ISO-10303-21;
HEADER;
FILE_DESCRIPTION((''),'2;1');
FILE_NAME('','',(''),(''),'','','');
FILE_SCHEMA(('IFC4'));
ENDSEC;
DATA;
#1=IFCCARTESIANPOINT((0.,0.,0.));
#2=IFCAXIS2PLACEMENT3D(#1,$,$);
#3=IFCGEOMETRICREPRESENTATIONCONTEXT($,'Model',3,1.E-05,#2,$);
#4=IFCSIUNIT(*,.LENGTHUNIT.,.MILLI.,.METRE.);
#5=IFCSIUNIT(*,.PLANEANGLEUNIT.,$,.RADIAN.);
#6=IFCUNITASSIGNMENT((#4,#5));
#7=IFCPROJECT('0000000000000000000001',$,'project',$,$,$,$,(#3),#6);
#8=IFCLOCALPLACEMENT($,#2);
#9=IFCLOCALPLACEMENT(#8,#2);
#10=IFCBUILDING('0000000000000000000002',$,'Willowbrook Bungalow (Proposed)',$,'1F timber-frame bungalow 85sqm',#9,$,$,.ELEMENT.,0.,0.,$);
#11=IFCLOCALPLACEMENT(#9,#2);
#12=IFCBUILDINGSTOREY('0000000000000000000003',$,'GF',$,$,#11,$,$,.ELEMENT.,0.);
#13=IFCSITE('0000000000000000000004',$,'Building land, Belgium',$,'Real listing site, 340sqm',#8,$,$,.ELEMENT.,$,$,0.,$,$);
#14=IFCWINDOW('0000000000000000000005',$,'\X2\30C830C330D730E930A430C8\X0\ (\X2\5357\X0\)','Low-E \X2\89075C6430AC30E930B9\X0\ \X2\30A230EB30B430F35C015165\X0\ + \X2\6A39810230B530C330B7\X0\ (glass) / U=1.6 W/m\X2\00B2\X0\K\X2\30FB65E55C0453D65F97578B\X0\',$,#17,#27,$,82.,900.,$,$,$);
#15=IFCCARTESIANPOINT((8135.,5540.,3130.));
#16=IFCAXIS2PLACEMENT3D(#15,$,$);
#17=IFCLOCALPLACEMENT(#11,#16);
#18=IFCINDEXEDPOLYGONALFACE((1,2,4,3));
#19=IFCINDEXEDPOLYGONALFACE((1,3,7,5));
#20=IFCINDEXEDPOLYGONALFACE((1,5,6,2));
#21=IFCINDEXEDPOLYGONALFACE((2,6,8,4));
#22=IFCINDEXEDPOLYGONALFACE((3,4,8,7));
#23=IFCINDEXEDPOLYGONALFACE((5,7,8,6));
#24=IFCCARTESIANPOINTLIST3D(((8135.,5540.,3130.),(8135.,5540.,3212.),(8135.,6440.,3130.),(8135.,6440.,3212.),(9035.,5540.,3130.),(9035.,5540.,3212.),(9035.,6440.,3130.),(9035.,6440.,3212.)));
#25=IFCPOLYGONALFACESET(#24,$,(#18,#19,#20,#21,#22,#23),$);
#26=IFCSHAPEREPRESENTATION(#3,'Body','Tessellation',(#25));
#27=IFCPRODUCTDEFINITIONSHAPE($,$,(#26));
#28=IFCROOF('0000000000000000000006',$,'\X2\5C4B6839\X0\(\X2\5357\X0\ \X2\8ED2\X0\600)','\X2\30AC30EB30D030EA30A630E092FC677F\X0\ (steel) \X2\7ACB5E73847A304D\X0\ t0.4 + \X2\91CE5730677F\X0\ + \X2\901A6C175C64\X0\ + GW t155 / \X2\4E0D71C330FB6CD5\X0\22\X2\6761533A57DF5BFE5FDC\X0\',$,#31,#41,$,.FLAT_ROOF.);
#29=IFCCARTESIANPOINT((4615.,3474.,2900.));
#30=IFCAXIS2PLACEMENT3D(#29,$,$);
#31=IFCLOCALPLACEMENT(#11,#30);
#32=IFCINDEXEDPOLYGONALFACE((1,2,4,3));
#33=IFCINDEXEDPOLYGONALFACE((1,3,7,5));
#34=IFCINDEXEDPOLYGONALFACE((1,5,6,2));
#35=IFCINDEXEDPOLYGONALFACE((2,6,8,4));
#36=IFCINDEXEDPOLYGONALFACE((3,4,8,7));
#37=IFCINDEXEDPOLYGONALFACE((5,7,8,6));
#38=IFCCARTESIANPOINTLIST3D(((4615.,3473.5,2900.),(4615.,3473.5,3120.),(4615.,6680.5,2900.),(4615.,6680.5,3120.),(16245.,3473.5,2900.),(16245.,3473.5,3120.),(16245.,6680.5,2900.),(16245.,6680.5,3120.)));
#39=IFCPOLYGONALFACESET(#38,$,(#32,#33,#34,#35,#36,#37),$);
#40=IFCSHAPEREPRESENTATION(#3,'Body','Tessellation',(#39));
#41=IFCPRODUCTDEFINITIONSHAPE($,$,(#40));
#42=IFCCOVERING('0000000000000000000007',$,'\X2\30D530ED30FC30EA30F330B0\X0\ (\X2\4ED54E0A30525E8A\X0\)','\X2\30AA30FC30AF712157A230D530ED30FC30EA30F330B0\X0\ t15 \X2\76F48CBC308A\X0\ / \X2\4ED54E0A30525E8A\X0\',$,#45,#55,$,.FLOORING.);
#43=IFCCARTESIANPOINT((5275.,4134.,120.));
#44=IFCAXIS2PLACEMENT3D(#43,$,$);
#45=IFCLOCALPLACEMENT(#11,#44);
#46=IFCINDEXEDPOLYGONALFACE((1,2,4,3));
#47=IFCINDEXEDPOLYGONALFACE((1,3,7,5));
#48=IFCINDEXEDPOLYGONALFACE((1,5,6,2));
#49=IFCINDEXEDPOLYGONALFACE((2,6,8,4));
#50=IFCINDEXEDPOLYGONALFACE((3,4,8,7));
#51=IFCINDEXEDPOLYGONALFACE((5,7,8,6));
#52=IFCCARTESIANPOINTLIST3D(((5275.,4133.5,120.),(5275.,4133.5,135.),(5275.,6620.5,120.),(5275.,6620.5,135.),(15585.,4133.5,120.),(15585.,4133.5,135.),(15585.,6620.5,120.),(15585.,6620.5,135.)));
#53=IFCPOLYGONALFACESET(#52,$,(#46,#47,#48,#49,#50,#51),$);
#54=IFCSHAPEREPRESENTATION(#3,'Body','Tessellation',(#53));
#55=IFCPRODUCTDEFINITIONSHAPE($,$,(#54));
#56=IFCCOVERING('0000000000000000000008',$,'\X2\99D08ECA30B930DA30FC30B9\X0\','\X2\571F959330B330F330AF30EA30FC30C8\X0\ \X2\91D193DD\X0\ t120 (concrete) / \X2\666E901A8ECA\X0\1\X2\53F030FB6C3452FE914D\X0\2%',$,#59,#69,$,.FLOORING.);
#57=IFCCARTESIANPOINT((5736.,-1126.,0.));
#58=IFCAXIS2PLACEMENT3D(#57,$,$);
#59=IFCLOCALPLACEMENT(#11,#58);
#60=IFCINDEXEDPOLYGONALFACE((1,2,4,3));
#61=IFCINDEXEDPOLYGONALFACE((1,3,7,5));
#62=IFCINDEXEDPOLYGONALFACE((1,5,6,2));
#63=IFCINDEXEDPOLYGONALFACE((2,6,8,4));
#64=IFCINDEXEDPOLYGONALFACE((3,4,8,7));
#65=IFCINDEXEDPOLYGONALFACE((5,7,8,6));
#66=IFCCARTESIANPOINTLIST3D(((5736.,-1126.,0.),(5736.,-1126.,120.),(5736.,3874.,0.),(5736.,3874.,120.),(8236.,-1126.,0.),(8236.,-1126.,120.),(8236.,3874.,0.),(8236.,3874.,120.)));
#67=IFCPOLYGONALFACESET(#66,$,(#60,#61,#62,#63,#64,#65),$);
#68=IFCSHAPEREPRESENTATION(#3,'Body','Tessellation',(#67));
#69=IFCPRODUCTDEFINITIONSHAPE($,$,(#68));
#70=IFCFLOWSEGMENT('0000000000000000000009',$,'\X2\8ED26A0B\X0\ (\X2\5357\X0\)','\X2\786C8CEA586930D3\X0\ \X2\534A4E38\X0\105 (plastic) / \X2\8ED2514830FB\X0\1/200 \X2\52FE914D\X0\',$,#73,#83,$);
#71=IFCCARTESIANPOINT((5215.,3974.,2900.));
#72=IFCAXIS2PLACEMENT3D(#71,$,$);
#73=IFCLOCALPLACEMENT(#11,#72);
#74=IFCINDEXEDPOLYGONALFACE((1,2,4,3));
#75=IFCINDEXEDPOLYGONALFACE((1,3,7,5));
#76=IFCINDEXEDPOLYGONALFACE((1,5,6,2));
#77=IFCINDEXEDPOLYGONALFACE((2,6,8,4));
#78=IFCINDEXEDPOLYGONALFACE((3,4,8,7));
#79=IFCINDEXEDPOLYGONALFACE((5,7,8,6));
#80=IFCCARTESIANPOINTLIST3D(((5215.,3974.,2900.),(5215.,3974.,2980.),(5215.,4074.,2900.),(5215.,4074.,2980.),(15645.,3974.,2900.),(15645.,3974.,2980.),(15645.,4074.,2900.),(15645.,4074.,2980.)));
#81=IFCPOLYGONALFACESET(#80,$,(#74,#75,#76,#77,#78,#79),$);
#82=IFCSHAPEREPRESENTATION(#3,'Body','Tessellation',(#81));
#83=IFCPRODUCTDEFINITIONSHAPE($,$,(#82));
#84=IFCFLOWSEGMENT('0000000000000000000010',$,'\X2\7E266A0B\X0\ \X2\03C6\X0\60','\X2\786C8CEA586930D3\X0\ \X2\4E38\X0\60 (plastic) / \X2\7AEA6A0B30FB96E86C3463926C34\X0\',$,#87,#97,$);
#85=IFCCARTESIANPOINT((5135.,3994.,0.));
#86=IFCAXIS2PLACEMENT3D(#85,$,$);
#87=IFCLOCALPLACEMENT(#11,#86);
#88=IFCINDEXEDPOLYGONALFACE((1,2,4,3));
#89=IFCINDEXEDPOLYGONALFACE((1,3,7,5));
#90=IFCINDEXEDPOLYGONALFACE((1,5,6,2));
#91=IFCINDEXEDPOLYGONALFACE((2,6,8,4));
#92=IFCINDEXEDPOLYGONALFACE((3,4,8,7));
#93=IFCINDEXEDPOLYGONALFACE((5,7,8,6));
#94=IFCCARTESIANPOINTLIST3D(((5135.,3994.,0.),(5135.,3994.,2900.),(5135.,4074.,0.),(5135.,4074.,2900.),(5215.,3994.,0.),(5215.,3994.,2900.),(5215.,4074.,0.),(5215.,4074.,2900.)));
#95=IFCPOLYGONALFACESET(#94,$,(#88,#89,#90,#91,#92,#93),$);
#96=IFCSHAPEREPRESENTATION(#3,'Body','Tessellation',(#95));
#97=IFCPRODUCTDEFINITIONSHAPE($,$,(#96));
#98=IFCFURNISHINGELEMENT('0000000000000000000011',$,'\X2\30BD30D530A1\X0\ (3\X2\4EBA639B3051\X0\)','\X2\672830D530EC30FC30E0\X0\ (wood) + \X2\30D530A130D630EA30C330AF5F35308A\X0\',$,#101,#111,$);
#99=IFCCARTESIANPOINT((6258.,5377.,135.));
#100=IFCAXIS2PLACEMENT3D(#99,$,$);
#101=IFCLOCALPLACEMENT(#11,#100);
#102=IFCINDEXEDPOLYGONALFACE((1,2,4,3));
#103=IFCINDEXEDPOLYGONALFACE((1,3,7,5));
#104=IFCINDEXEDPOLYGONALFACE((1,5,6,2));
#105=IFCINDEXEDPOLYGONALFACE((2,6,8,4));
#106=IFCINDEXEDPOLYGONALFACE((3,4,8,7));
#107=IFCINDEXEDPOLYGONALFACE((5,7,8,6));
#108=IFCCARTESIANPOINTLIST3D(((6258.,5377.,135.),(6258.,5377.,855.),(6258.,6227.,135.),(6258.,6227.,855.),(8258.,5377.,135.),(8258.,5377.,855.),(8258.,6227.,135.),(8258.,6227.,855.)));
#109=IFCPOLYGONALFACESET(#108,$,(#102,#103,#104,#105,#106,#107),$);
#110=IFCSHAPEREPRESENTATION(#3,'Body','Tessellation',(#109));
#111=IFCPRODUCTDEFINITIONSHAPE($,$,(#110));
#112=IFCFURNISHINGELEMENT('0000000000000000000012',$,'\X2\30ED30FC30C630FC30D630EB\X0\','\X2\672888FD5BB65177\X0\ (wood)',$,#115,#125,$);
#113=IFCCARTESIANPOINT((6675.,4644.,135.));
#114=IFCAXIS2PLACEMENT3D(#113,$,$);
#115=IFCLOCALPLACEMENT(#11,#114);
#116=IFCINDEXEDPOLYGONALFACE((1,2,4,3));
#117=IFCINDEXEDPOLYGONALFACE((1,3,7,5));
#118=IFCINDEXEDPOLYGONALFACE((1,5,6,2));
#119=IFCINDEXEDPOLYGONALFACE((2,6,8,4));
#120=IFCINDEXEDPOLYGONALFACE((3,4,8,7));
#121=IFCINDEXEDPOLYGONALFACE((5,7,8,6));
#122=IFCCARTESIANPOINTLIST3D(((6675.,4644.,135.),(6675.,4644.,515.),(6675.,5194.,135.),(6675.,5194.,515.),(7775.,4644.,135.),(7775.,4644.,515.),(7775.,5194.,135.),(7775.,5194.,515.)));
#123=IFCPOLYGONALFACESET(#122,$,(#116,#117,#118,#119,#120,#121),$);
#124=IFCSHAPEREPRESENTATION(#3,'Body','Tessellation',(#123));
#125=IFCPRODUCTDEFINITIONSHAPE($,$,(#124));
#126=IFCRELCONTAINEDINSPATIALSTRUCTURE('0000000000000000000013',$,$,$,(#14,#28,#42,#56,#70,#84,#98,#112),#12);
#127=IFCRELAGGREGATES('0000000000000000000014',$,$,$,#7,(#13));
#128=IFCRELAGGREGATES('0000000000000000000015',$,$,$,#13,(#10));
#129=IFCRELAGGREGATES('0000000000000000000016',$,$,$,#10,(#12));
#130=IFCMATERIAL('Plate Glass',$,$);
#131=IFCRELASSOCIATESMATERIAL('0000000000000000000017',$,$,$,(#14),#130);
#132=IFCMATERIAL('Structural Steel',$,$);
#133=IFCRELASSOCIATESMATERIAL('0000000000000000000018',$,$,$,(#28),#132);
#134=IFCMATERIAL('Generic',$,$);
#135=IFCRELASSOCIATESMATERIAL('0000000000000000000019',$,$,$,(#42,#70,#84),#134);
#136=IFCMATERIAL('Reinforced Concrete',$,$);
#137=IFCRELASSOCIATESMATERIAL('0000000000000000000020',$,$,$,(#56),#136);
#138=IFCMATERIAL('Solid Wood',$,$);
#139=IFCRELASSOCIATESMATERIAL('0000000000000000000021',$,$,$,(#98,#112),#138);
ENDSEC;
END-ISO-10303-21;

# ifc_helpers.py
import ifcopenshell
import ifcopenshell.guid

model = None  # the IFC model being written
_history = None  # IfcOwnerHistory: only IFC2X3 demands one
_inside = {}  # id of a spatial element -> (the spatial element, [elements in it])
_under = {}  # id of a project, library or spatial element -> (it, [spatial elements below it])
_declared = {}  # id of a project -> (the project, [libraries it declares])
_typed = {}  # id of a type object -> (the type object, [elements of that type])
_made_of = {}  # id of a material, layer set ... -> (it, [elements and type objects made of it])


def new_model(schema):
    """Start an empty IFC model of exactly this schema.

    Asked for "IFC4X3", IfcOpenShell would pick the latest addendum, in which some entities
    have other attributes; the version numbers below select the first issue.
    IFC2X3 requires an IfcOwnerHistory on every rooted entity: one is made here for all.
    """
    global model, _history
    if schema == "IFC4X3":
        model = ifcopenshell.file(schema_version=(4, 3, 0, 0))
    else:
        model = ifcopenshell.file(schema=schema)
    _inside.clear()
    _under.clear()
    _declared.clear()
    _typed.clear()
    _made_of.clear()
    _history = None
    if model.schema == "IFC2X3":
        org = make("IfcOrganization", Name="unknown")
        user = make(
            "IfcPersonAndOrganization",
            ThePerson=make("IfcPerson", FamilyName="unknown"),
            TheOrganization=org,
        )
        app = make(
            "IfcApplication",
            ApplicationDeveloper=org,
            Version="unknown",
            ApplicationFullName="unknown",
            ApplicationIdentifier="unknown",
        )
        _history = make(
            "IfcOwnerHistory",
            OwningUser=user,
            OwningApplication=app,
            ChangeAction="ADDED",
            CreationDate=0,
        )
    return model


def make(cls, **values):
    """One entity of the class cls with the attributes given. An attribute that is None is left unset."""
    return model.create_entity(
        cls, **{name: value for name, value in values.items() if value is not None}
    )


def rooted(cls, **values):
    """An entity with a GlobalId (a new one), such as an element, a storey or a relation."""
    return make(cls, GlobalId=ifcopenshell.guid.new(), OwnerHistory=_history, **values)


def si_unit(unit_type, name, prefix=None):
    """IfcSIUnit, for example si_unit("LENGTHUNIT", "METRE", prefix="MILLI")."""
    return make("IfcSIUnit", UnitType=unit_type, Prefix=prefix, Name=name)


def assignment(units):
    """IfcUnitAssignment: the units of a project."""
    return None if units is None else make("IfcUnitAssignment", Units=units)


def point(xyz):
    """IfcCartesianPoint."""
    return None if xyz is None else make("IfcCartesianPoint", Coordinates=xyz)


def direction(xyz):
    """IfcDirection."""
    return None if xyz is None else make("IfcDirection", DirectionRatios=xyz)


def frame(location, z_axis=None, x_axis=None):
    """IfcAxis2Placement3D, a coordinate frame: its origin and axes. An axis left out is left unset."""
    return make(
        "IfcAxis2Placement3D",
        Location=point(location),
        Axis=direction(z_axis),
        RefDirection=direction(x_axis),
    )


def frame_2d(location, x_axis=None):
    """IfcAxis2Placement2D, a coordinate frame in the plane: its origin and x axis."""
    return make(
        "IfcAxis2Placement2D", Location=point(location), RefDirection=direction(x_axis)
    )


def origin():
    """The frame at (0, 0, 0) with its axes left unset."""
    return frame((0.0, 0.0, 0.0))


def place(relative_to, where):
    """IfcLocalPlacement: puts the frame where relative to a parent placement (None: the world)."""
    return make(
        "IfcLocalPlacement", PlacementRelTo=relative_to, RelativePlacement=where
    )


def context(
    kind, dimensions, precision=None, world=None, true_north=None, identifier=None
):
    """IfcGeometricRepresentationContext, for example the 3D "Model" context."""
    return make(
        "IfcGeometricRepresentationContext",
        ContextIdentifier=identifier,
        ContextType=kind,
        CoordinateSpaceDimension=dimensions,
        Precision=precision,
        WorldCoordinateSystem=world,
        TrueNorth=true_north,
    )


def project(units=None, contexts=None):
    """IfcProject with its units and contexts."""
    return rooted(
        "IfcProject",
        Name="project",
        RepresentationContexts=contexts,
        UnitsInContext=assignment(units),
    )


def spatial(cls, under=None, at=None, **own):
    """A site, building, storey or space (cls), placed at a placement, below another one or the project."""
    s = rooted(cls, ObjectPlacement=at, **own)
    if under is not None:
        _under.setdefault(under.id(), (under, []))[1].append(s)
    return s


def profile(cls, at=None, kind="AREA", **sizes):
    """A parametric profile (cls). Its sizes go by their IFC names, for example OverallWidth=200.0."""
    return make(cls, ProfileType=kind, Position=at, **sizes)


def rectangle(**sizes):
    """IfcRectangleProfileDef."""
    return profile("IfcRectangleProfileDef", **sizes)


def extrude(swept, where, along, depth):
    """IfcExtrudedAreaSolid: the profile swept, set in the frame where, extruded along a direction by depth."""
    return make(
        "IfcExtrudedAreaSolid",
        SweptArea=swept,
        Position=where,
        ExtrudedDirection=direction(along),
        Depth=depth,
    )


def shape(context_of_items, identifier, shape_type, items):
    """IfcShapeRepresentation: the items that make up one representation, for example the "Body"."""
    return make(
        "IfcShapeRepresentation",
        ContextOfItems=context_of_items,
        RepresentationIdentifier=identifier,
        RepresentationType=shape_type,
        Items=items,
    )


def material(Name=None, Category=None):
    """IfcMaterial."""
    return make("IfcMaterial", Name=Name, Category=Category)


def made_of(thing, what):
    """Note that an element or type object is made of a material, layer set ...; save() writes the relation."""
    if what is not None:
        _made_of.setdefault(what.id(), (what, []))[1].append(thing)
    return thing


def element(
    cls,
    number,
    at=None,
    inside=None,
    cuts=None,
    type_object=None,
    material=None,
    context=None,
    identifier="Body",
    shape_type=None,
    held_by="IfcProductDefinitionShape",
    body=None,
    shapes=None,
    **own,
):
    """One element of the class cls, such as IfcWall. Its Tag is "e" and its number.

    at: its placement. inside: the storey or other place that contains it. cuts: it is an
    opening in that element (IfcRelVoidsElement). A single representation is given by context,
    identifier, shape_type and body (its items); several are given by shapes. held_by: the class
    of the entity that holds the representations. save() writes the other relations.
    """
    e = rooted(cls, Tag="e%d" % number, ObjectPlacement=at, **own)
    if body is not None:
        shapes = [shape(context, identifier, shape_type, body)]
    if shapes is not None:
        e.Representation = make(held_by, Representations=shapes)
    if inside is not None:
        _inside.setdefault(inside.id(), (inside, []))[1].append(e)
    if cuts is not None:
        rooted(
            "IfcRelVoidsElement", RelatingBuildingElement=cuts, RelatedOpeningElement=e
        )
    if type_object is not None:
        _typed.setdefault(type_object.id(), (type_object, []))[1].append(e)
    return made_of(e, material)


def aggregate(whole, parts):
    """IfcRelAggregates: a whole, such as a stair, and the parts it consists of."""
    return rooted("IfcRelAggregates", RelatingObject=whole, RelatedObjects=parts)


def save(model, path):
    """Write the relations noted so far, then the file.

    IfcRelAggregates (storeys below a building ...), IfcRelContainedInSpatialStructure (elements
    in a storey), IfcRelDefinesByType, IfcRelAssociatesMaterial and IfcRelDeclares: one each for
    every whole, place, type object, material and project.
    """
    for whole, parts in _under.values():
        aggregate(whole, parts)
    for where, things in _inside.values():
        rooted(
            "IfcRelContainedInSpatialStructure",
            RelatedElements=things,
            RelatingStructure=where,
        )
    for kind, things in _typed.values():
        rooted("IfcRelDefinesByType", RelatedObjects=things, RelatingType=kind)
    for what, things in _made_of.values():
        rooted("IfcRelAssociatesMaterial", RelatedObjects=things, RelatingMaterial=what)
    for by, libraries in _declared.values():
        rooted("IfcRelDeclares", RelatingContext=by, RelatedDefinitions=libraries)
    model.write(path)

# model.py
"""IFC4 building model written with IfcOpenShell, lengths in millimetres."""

from ifc_helpers import new_model, si_unit, frame, frame_2d, origin, place, context, project, spatial, rectangle, extrude, material, element, save


model = new_model("IFC4")

# Units and contexts
model_context = context("Model", 3, precision=1e-05, world=origin())
ifc_project = project(units=[si_unit("LENGTHUNIT", "METRE", prefix="MILLI"), si_unit("PLANEANGLEUNIT", "RADIAN")], contexts=[model_context])

# Site, building, storey
site_placement = place(None, origin())
site = spatial("IfcSite", under=ifc_project, at=site_placement, Name="Building land, Belgium", ObjectType="Real listing site, 340sqm", CompositionType="ELEMENT", RefElevation=0.0)
building_placement = place(site_placement, origin())
building = spatial("IfcBuilding", under=site, at=building_placement, Name="Willowbrook Bungalow (Proposed)", ObjectType="1F timber-frame bungalow 85sqm", CompositionType="ELEMENT", ElevationOfRefHeight=0.0, ElevationOfTerrain=0.0)
storey_placement = place(building_placement, origin())
storey = spatial("IfcBuildingStorey", under=building, at=storey_placement, Name="GF", CompositionType="ELEMENT", Elevation=0.0)

# Shared definitions
ifc_material_1 = material(Name="Solid Wood")

# Shared definitions
ifc_material_2 = material(Name="Reinforced Concrete")

# Shared definitions
ifc_material_3 = material(Name="Plate Glass")

# Window
window_1_placement = place(storey_placement, frame((8135.0, 5540.0, 3130.0)))
element("IfcWindow", 1, at=window_1_placement, inside=storey, material=ifc_material_3, Name="トップライト (南)", Description="Low-E 複層ガラス アルゴン封入 + 樹脂サッシ (glass) / U=1.6 W/m²K・日射取得型", OverallHeight=82.0, OverallWidth=900.0, context=model_context, shape_type="SweptSolid", body=[
    extrude(rectangle(XDim=900.0, YDim=900.0, at=frame_2d((450.0, 450.0))), frame((8135.0, 5540.0, 3130.0)), (0.0, 0.0, 1.0), 82.0),
])

# Roof
ifc_material_4 = material(Name="Structural Steel")
roof_1_placement = place(storey_placement, frame((4615.0, 3474.0, 2900.0)))
element("IfcRoof", 2, at=roof_1_placement, inside=storey, material=ifc_material_4, Name="屋根(南 軒600)", Description="ガルバリウム鋼板 (steel) 立平葺き t0.4 + 野地板 + 通気層 + GW t155 / 不燃・法22条区域対応", PredefinedType="FLAT_ROOF", context=model_context, shape_type="SweptSolid", body=[
    extrude(rectangle(XDim=11630.0, YDim=3207.0, at=frame_2d((5815.0, 1603.0))), frame((4615.0, 3474.0, 2900.0)), (0.0, 0.0, 1.0), 220.0),
])

# Coverings
ifc_material_5 = material(Name="Generic")
covering_1_placement = place(storey_placement, frame((5275.0, 4134.0, 120.0)))
element("IfcCovering", 3, at=covering_1_placement, inside=storey, material=ifc_material_5, Name="フローリング (仕上げ床)", Description="オーク無垢フローリング t15 直貼り / 仕上げ床", PredefinedType="FLOORING", context=model_context, shape_type="SweptSolid", body=[
    extrude(rectangle(XDim=10310.0, YDim=2487.0, at=frame_2d((5155.0, 1243.0))), frame((5275.0, 4134.0, 120.0)), (0.0, 0.0, 1.0), 15.0),
])
covering_2_placement = place(storey_placement, frame((5736.0, -1126.0, 0.0)))
element("IfcCovering", 4, at=covering_2_placement, inside=storey, material=ifc_material_2, Name="駐車スペース", Description="土間コンクリート 金鏝 t120 (concrete) / 普通車1台・水勾配2%", PredefinedType="FLOORING", context=model_context, shape_type="SweptSolid", body=[
    extrude(rectangle(XDim=2500.0, YDim=5000.0, at=frame_2d((1250.0, 2500.0))), frame((5736.0, -1126.0, 0.0)), (0.0, 0.0, 1.0), 120.0),
])

# Flow segments
flow_segment_1_placement = place(storey_placement, frame((5215.0, 3974.0, 2900.0)))
element("IfcFlowSegment", 5, at=flow_segment_1_placement, inside=storey, material=ifc_material_5, Name="軒樋 (南)", Description="硬質塩ビ 半丸105 (plastic) / 軒先・1/200 勾配", context=model_context, shape_type="SweptSolid", body=[
    extrude(rectangle(XDim=10430.0, YDim=100.0, at=frame_2d((5215.0, 50.0))), frame((5215.0, 3974.0, 2900.0)), (0.0, 0.0, 1.0), 80.0),
])
flow_segment_2_placement = place(storey_placement, frame((5135.0, 3994.0, 0.0)))
element("IfcFlowSegment", 6, at=flow_segment_2_placement, inside=storey, material=ifc_material_5, Name="縦樋 φ60", Description="硬質塩ビ 丸60 (plastic) / 竪樋・雨水排水", context=model_context, shape_type="SweptSolid", body=[
    extrude(rectangle(XDim=80.0, YDim=80.0, at=frame_2d((40.0, 40.0))), frame((5135.0, 3994.0, 0.0)), (0.0, 0.0, 1.0), 2900.0),
])

# Furnishing elements
furnishing_1_placement = place(storey_placement, frame((6258.0, 5377.0, 135.0)))
element("IfcFurnishingElement", 7, at=furnishing_1_placement, inside=storey, material=ifc_material_1, Name="ソファ (3人掛け)", Description="木フレーム (wood) + ファブリック張り", context=model_context, shape_type="SweptSolid", body=[
    extrude(rectangle(XDim=2000.0, YDim=850.0, at=frame_2d((1000.0, 425.0))), frame((6258.0, 5377.0, 135.0)), (0.0, 0.0, 1.0), 720.0),
])
furnishing_2_placement = place(storey_placement, frame((6675.0, 4644.0, 135.0)))
element("IfcFurnishingElement", 8, at=furnishing_2_placement, inside=storey, material=ifc_material_1, Name="ローテーブル", Description="木製家具 (wood)", context=model_context, shape_type="SweptSolid", body=[
    extrude(rectangle(XDim=1100.0, YDim=550.0, at=frame_2d((550.0, 275.0))), frame((6675.0, 4644.0, 135.0)), (0.0, 0.0, 1.0), 380.0),
])

save(model, "model.ifc")
